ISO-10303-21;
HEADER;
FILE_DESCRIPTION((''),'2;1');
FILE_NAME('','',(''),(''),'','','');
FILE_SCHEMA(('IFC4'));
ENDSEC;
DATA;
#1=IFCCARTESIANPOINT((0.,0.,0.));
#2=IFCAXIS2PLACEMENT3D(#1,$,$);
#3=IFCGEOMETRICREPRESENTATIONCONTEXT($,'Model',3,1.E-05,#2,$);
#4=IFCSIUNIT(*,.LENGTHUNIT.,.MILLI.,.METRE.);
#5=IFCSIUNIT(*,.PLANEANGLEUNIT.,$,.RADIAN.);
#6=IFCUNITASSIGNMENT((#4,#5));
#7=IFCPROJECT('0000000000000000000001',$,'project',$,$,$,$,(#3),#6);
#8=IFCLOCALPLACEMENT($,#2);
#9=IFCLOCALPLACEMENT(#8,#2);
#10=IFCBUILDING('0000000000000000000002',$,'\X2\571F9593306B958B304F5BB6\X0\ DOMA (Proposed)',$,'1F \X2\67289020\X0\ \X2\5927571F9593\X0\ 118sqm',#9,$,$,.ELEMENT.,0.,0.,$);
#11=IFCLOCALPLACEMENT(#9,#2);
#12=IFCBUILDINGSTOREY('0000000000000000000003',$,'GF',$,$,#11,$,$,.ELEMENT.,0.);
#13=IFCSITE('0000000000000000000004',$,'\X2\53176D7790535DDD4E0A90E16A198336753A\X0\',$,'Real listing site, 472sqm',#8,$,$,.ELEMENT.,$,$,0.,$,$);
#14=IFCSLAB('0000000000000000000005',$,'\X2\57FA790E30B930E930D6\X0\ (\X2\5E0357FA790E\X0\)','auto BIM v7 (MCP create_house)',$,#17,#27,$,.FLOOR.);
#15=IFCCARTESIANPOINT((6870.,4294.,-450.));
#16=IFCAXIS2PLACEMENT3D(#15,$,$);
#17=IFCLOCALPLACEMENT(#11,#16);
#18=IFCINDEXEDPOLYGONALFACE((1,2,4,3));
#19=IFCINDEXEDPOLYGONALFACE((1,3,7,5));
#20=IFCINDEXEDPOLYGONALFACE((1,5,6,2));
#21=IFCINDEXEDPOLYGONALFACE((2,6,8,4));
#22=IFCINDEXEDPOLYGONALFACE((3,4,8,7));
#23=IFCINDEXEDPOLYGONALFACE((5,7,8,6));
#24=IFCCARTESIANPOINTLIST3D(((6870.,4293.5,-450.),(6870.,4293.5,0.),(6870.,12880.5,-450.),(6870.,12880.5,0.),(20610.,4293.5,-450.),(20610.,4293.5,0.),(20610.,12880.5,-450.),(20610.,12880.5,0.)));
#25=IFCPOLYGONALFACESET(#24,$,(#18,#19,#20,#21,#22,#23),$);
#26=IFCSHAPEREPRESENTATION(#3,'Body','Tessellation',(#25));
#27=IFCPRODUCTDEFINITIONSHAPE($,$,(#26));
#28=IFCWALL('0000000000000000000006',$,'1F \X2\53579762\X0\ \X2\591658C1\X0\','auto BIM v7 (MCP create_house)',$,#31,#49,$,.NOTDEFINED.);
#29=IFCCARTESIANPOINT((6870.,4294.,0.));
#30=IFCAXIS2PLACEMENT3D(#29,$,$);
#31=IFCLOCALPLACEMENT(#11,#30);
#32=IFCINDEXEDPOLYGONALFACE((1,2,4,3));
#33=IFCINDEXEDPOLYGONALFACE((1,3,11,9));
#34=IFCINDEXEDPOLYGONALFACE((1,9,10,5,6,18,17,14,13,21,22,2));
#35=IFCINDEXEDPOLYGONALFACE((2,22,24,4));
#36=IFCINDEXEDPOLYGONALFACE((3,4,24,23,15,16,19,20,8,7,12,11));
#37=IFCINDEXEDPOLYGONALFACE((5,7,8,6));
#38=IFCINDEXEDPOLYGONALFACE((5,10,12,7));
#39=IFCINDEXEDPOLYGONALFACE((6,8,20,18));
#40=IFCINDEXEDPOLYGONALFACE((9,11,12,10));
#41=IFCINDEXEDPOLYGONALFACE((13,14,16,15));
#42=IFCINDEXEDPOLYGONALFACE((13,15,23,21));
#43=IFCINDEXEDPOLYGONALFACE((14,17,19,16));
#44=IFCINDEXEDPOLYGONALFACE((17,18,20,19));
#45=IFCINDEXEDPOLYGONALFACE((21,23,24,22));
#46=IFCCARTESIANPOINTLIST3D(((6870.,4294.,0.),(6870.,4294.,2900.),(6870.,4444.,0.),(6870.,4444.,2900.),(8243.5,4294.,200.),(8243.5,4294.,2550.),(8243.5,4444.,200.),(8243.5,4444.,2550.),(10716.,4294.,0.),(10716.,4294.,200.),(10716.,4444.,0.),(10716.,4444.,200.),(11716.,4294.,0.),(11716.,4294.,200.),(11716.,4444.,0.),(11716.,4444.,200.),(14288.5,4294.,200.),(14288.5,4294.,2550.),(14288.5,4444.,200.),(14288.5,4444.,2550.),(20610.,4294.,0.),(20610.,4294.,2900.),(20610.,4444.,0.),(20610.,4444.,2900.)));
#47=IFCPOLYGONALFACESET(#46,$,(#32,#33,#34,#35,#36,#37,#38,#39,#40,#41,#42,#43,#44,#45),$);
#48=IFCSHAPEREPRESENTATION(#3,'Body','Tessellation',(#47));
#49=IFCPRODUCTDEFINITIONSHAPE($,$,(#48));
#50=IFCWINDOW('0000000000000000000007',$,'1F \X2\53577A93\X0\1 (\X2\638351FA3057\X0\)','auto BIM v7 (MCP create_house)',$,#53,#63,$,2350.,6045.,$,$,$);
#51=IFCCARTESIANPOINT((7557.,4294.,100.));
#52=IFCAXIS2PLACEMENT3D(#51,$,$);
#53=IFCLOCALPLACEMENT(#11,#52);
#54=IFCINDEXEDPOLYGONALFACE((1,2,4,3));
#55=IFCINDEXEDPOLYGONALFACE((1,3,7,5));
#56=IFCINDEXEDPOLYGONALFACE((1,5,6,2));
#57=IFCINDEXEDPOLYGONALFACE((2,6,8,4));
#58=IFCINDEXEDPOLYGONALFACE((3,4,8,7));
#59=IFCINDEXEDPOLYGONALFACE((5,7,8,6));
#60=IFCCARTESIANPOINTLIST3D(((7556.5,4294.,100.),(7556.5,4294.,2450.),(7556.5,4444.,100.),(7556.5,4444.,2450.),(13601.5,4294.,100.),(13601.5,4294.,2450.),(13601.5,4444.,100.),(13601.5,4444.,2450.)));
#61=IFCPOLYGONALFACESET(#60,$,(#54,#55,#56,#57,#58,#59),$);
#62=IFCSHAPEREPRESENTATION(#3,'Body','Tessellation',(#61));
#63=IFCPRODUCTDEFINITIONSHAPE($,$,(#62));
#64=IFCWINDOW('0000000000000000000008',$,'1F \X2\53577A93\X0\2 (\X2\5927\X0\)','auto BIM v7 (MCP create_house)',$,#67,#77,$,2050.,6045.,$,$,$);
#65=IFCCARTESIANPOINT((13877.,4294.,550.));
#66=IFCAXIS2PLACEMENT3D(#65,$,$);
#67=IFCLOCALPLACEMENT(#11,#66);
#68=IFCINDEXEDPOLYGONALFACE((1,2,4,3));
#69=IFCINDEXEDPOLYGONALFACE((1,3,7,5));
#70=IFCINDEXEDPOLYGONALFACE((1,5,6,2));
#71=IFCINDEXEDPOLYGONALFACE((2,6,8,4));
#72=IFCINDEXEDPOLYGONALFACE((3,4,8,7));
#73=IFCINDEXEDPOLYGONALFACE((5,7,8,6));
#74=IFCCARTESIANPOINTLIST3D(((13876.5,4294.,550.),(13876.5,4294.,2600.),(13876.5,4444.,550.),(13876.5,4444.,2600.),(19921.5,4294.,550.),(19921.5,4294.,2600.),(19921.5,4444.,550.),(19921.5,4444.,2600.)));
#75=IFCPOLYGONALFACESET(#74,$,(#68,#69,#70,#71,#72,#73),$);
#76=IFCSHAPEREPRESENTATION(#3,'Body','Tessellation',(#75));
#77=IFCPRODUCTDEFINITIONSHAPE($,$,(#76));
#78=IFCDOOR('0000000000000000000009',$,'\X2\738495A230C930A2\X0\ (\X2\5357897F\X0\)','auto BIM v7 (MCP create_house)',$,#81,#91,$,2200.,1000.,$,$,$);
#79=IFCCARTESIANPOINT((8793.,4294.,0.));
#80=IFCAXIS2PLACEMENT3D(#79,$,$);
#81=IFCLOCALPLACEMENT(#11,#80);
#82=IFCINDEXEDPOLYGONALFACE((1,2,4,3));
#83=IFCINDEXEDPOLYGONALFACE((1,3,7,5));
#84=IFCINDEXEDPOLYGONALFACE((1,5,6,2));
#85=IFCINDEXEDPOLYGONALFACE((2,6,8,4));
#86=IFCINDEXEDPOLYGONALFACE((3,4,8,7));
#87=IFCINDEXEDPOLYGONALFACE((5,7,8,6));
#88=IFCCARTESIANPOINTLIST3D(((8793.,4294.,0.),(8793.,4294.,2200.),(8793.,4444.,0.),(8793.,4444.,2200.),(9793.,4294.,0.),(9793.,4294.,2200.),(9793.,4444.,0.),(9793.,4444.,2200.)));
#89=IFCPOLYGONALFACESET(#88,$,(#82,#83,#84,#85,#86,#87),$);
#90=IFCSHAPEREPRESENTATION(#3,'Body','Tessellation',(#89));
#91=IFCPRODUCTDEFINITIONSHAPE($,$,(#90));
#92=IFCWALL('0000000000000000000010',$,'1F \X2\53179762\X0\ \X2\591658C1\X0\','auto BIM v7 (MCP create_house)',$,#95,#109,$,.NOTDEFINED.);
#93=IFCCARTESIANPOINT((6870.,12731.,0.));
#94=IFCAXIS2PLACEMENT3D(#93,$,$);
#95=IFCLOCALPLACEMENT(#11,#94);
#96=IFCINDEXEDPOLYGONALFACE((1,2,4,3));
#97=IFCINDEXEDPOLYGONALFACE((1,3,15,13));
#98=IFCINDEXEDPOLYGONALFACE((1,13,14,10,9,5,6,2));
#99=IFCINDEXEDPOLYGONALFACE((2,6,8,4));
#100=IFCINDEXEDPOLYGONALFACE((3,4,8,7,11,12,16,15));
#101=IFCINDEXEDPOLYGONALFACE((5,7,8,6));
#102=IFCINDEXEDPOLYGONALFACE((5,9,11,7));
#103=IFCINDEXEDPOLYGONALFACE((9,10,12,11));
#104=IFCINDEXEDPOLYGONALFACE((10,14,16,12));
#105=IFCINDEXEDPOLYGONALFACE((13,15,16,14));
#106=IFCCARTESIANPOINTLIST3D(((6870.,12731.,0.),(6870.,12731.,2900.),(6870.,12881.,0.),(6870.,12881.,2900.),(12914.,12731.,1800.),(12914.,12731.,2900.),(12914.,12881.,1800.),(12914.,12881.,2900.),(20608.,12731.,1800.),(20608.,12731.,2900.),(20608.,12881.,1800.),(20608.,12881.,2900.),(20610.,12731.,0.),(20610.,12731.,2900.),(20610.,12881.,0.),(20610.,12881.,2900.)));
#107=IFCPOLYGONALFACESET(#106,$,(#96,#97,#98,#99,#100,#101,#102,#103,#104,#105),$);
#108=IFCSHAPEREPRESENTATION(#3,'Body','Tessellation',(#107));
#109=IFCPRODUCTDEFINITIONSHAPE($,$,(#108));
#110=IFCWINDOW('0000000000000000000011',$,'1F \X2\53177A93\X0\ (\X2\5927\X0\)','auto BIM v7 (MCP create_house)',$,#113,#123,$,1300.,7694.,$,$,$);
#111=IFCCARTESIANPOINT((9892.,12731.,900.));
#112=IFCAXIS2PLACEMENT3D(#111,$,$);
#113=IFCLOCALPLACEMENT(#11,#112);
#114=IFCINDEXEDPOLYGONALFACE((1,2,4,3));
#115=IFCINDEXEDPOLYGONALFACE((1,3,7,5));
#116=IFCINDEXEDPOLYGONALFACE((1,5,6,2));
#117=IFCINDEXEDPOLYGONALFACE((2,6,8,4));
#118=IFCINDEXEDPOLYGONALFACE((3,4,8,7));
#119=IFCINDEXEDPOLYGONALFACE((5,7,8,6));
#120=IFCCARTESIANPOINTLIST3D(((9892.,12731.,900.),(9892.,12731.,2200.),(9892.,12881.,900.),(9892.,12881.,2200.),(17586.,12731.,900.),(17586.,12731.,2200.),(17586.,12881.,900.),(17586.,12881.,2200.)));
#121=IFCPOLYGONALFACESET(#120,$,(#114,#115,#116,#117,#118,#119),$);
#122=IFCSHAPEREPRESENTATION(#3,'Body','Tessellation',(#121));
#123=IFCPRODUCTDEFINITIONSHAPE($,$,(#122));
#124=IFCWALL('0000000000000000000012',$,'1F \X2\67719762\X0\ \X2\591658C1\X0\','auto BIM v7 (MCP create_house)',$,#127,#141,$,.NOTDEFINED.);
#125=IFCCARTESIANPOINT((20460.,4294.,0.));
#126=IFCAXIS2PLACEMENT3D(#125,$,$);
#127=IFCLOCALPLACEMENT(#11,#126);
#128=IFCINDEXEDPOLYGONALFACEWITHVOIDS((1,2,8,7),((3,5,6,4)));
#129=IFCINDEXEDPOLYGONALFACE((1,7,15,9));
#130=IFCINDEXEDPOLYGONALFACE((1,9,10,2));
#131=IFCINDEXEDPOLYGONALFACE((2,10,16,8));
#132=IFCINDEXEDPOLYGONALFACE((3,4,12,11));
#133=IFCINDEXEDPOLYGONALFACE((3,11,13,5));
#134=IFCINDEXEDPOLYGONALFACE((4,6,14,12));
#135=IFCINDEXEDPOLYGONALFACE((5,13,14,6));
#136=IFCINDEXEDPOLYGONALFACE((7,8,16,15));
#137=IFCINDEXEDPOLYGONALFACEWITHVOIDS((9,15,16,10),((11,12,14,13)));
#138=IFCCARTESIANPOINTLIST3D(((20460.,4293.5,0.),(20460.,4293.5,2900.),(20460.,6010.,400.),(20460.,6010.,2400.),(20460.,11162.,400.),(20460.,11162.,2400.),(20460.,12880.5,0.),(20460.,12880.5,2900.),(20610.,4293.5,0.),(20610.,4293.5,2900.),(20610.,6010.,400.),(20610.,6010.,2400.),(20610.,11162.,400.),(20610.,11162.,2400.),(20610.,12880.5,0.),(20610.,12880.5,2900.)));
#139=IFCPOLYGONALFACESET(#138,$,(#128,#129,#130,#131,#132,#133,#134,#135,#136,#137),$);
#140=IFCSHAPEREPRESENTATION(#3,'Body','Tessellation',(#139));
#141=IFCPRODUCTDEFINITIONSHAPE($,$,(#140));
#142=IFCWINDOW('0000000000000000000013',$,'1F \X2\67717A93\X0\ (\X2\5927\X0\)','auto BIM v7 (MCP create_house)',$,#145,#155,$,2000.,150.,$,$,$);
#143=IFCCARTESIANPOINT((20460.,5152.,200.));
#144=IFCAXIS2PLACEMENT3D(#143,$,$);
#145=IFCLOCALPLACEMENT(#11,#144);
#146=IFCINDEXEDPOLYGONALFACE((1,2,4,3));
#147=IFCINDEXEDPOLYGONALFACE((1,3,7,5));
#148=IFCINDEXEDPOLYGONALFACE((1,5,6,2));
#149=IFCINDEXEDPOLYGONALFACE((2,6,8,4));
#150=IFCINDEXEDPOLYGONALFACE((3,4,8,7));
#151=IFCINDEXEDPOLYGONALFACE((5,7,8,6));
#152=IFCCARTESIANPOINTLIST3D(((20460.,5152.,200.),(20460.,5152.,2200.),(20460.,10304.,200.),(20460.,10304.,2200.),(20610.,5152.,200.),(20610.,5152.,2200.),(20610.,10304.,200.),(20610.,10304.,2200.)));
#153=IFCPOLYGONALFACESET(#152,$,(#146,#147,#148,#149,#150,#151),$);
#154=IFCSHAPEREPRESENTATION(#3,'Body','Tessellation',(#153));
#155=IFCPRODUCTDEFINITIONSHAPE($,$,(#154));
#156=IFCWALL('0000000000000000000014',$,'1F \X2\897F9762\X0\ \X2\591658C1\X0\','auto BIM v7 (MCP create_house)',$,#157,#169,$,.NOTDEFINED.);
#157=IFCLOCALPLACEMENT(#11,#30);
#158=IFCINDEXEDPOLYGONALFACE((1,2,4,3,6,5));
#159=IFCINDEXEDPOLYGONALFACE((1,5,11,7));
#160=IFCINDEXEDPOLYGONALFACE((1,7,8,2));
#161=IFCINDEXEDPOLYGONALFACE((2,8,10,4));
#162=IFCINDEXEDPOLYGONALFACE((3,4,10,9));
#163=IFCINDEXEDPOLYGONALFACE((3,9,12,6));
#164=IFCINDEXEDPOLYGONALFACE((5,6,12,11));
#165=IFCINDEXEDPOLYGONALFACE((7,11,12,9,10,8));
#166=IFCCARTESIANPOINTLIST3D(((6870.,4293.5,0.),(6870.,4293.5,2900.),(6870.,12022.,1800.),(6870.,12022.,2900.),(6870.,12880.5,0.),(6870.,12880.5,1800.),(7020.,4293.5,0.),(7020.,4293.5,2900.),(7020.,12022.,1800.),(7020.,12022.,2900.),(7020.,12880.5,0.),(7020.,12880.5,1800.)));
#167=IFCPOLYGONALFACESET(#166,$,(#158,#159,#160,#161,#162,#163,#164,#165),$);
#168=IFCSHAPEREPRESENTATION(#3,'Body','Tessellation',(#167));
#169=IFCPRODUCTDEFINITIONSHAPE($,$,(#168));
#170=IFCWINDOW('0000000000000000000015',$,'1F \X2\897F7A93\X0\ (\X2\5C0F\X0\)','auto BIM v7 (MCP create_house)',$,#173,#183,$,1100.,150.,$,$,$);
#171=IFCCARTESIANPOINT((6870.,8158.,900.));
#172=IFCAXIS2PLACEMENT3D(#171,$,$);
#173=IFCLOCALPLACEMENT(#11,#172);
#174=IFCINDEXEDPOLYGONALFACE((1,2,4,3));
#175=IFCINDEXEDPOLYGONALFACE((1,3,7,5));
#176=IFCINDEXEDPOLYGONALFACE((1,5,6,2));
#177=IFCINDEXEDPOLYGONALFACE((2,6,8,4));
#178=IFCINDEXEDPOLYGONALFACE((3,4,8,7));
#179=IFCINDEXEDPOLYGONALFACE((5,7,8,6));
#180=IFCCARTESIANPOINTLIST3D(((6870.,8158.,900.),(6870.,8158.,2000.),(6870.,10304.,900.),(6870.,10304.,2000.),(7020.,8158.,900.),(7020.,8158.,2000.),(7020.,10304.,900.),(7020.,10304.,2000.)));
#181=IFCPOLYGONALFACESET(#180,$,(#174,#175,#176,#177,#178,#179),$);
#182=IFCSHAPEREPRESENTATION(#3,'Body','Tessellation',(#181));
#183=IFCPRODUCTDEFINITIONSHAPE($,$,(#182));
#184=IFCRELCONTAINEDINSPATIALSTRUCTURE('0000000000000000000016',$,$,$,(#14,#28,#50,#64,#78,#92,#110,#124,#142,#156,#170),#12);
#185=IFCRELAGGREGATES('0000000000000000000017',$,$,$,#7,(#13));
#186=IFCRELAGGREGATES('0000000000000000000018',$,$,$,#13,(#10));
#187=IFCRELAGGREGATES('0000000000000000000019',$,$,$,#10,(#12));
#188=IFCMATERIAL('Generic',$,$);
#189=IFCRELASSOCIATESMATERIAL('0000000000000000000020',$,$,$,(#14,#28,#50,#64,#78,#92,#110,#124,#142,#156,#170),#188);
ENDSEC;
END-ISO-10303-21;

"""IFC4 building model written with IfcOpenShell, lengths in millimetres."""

from ifc_helpers import new_model, si_unit, frame, frame_2d, origin, place, context, project, spatial, rectangle, extrude, material, element, fill, save


model = new_model("IFC4")

# Units and contexts
model_context = context("Model", 3, precision=1e-05, world=origin())
ifc_project = project(units=[si_unit("LENGTHUNIT", "METRE", prefix="MILLI"), si_unit("PLANEANGLEUNIT", "RADIAN")], contexts=[model_context])

# Site, building, storey
site_placement = place(None, origin())
site = spatial("IfcSite", under=ifc_project, at=site_placement, Name="北海道川上郡標茶町", ObjectType="Real listing site, 472sqm", CompositionType="ELEMENT", RefElevation=0.0)
building_placement = place(site_placement, origin())
building = spatial("IfcBuilding", under=site, at=building_placement, Name="土間に開く家 DOMA (Proposed)", ObjectType="1F 木造 大土間 118sqm", CompositionType="ELEMENT", ElevationOfRefHeight=0.0, ElevationOfTerrain=0.0)
storey_placement = place(building_placement, origin())
storey = spatial("IfcBuildingStorey", under=building, at=storey_placement, Name="GF", CompositionType="ELEMENT", Elevation=0.0)

# Slab
ifc_material = material(Name="Generic")
slab_1_placement = place(storey_placement, frame((6870.0, 4294.0, -450.0)))
element("IfcSlab", 1, at=slab_1_placement, inside=storey, material=ifc_material, Name="基礎スラブ (布基礎)", Description="auto BIM v7 (MCP create_house)", PredefinedType="FLOOR", context=model_context, shape_type="SweptSolid", body=[
    extrude(rectangle(XDim=13740.0, YDim=8587.0, at=frame_2d((6870.0, 4293.0))), frame((6870.0, 4294.0, -450.0)), (0.0, 0.0, 1.0), 450.0),
])

# Wall, openings, windows, door
wall_1_placement = place(storey_placement, frame((6870.0, 4294.0, 0.0)))
wall_1 = element("IfcWall", 2, at=wall_1_placement, inside=storey, material=ifc_material, Name="1F 南面 外壁", Description="auto BIM v7 (MCP create_house)", PredefinedType="NOTDEFINED", context=model_context, shape_type="SweptSolid", body=[
    extrude(rectangle(XDim=13740.0, YDim=150.0, at=frame_2d((6870.0, 75.0))), frame((6870.0, 4294.0, 0.0)), (0.0, 0.0, 1.0), 2900.0),
])
opening_1_placement = place(storey_placement, frame((7557.0, 4294.0, 100.0)))
opening_1 = element("IfcOpeningElement", 3, at=opening_1_placement, cuts=wall_1, PredefinedType="NOTDEFINED", context=model_context, shape_type="SweptSolid", body=[
    extrude(rectangle(XDim=6045.0, YDim=150.0, at=frame_2d((3022.0, 75.0))), frame((7557.0, 4294.0, 100.0)), (0.0, 0.0, 1.0), 2350.0),
])
opening_2_placement = place(storey_placement, frame((13877.0, 4294.0, 550.0)))
opening_2 = element("IfcOpeningElement", 4, at=opening_2_placement, cuts=wall_1, PredefinedType="NOTDEFINED", context=model_context, shape_type="SweptSolid", body=[
    extrude(rectangle(XDim=6045.0, YDim=150.0, at=frame_2d((3022.0, 75.0))), frame((13877.0, 4294.0, 550.0)), (0.0, 0.0, 1.0), 2050.0),
])
opening_3_placement = place(storey_placement, frame((8793.0, 4294.0, 0.0)))
opening_3 = element("IfcOpeningElement", 5, at=opening_3_placement, cuts=wall_1, PredefinedType="NOTDEFINED", context=model_context, shape_type="SweptSolid", body=[
    extrude(rectangle(XDim=1000.0, YDim=150.0, at=frame_2d((500.0, 75.0))), frame((8793.0, 4294.0, 0.0)), (0.0, 0.0, 1.0), 2200.0),
])
window_1_placement = place(storey_placement, frame((7557.0, 4294.0, 100.0)))
window_1 = element("IfcWindow", 6, at=window_1_placement, inside=storey, material=ifc_material, Name="1F 南窓1 (掃出し)", Description="auto BIM v7 (MCP create_house)", OverallHeight=2350.0, OverallWidth=6045.0, context=model_context, shape_type="SweptSolid", body=[
    extrude(rectangle(XDim=6045.0, YDim=150.0, at=frame_2d((3022.0, 75.0))), frame((7557.0, 4294.0, 100.0)), (0.0, 0.0, 1.0), 2350.0),
])
fill(opening_1, window_1)
window_2_placement = place(storey_placement, frame((13877.0, 4294.0, 550.0)))
window_2 = element("IfcWindow", 7, at=window_2_placement, inside=storey, material=ifc_material, Name="1F 南窓2 (大)", Description="auto BIM v7 (MCP create_house)", OverallHeight=2050.0, OverallWidth=6045.0, context=model_context, shape_type="SweptSolid", body=[
    extrude(rectangle(XDim=6045.0, YDim=150.0, at=frame_2d((3022.0, 75.0))), frame((13877.0, 4294.0, 550.0)), (0.0, 0.0, 1.0), 2050.0),
])
fill(opening_2, window_2)
door_placement = place(storey_placement, frame((8793.0, 4294.0, 0.0)))
door = element("IfcDoor", 8, at=door_placement, inside=storey, material=ifc_material, Name="玄関ドア (南西)", Description="auto BIM v7 (MCP create_house)", OverallHeight=2200.0, OverallWidth=1000.0, context=model_context, shape_type="SweptSolid", body=[
    extrude(rectangle(XDim=1000.0, YDim=150.0, at=frame_2d((500.0, 75.0))), frame((8793.0, 4294.0, 0.0)), (0.0, 0.0, 1.0), 2200.0),
])
fill(opening_3, door)

# Walls, openings, windows
wall_2_placement = place(storey_placement, frame((6870.0, 12731.0, 0.0)))
wall_2 = element("IfcWall", 9, at=wall_2_placement, inside=storey, material=ifc_material, Name="1F 北面 外壁", Description="auto BIM v7 (MCP create_house)", PredefinedType="NOTDEFINED", context=model_context, shape_type="SweptSolid", body=[
    extrude(rectangle(XDim=13740.0, YDim=150.0, at=frame_2d((6870.0, 75.0))), frame((6870.0, 12731.0, 0.0)), (0.0, 0.0, 1.0), 2900.0),
])
opening_4_placement = place(storey_placement, frame((9892.0, 12731.0, 900.0)))
opening_4 = element("IfcOpeningElement", 10, at=opening_4_placement, cuts=wall_2, PredefinedType="NOTDEFINED", context=model_context, shape_type="SweptSolid", body=[
    extrude(rectangle(XDim=7694.0, YDim=150.0, at=frame_2d((3847.0, 75.0))), frame((9892.0, 12731.0, 900.0)), (0.0, 0.0, 1.0), 1300.0),
])
window_3_placement = place(storey_placement, frame((9892.0, 12731.0, 900.0)))
window_3 = element("IfcWindow", 11, at=window_3_placement, inside=storey, material=ifc_material, Name="1F 北窓 (大)", Description="auto BIM v7 (MCP create_house)", OverallHeight=1300.0, OverallWidth=7694.0, context=model_context, shape_type="SweptSolid", body=[
    extrude(rectangle(XDim=7694.0, YDim=150.0, at=frame_2d((3847.0, 75.0))), frame((9892.0, 12731.0, 900.0)), (0.0, 0.0, 1.0), 1300.0),
])
fill(opening_4, window_3)
wall_3_placement = place(storey_placement, frame((20460.0, 4294.0, 0.0)))
wall_3 = element("IfcWall", 12, at=wall_3_placement, inside=storey, material=ifc_material, Name="1F 東面 外壁", Description="auto BIM v7 (MCP create_house)", PredefinedType="NOTDEFINED", context=model_context, shape_type="SweptSolid", body=[
    extrude(rectangle(XDim=150.0, YDim=8587.0, at=frame_2d((75.0, 4293.0))), frame((20460.0, 4294.0, 0.0)), (0.0, 0.0, 1.0), 2900.0),
])
opening_5_placement = place(storey_placement, frame((20460.0, 5152.0, 200.0)))
opening_5 = element("IfcOpeningElement", 13, at=opening_5_placement, cuts=wall_3, PredefinedType="NOTDEFINED", context=model_context, shape_type="SweptSolid", body=[
    extrude(rectangle(XDim=150.0, YDim=5152.0, at=frame_2d((75.0, 2576.0))), frame((20460.0, 5152.0, 200.0)), (0.0, 0.0, 1.0), 2000.0),
])
window_4_placement = place(storey_placement, frame((20460.0, 5152.0, 200.0)))
window_4 = element("IfcWindow", 14, at=window_4_placement, inside=storey, material=ifc_material, Name="1F 東窓 (大)", Description="auto BIM v7 (MCP create_house)", OverallHeight=2000.0, OverallWidth=150.0, context=model_context, shape_type="SweptSolid", body=[
    extrude(rectangle(XDim=150.0, YDim=5152.0, at=frame_2d((75.0, 2576.0))), frame((20460.0, 5152.0, 200.0)), (0.0, 0.0, 1.0), 2000.0),
])
fill(opening_5, window_4)
wall_4_placement = place(storey_placement, frame((6870.0, 4294.0, 0.0)))
wall_4 = element("IfcWall", 15, at=wall_4_placement, inside=storey, material=ifc_material, Name="1F 西面 外壁", Description="auto BIM v7 (MCP create_house)", PredefinedType="NOTDEFINED", context=model_context, shape_type="SweptSolid", body=[
    extrude(rectangle(XDim=150.0, YDim=8587.0, at=frame_2d((75.0, 4293.0))), frame((6870.0, 4294.0, 0.0)), (0.0, 0.0, 1.0), 2900.0),
])
opening_6_placement = place(storey_placement, frame((6870.0, 8158.0, 900.0)))
opening_6 = element("IfcOpeningElement", 16, at=opening_6_placement, cuts=wall_4, PredefinedType="NOTDEFINED", context=model_context, shape_type="SweptSolid", body=[
    extrude(rectangle(XDim=150.0, YDim=2146.0, at=frame_2d((75.0, 1073.0))), frame((6870.0, 8158.0, 900.0)), (0.0, 0.0, 1.0), 1100.0),
])
window_5_placement = place(storey_placement, frame((6870.0, 8158.0, 900.0)))
window_5 = element("IfcWindow", 17, at=window_5_placement, inside=storey, material=ifc_material, Name="1F 西窓 (小)", Description="auto BIM v7 (MCP create_house)", OverallHeight=1100.0, OverallWidth=150.0, context=model_context, shape_type="SweptSolid", body=[
    extrude(rectangle(XDim=150.0, YDim=2146.0, at=frame_2d((75.0, 1073.0))), frame((6870.0, 8158.0, 900.0)), (0.0, 0.0, 1.0), 1100.0),
])
fill(opening_6, window_5)

save(model, "model.ifc")
